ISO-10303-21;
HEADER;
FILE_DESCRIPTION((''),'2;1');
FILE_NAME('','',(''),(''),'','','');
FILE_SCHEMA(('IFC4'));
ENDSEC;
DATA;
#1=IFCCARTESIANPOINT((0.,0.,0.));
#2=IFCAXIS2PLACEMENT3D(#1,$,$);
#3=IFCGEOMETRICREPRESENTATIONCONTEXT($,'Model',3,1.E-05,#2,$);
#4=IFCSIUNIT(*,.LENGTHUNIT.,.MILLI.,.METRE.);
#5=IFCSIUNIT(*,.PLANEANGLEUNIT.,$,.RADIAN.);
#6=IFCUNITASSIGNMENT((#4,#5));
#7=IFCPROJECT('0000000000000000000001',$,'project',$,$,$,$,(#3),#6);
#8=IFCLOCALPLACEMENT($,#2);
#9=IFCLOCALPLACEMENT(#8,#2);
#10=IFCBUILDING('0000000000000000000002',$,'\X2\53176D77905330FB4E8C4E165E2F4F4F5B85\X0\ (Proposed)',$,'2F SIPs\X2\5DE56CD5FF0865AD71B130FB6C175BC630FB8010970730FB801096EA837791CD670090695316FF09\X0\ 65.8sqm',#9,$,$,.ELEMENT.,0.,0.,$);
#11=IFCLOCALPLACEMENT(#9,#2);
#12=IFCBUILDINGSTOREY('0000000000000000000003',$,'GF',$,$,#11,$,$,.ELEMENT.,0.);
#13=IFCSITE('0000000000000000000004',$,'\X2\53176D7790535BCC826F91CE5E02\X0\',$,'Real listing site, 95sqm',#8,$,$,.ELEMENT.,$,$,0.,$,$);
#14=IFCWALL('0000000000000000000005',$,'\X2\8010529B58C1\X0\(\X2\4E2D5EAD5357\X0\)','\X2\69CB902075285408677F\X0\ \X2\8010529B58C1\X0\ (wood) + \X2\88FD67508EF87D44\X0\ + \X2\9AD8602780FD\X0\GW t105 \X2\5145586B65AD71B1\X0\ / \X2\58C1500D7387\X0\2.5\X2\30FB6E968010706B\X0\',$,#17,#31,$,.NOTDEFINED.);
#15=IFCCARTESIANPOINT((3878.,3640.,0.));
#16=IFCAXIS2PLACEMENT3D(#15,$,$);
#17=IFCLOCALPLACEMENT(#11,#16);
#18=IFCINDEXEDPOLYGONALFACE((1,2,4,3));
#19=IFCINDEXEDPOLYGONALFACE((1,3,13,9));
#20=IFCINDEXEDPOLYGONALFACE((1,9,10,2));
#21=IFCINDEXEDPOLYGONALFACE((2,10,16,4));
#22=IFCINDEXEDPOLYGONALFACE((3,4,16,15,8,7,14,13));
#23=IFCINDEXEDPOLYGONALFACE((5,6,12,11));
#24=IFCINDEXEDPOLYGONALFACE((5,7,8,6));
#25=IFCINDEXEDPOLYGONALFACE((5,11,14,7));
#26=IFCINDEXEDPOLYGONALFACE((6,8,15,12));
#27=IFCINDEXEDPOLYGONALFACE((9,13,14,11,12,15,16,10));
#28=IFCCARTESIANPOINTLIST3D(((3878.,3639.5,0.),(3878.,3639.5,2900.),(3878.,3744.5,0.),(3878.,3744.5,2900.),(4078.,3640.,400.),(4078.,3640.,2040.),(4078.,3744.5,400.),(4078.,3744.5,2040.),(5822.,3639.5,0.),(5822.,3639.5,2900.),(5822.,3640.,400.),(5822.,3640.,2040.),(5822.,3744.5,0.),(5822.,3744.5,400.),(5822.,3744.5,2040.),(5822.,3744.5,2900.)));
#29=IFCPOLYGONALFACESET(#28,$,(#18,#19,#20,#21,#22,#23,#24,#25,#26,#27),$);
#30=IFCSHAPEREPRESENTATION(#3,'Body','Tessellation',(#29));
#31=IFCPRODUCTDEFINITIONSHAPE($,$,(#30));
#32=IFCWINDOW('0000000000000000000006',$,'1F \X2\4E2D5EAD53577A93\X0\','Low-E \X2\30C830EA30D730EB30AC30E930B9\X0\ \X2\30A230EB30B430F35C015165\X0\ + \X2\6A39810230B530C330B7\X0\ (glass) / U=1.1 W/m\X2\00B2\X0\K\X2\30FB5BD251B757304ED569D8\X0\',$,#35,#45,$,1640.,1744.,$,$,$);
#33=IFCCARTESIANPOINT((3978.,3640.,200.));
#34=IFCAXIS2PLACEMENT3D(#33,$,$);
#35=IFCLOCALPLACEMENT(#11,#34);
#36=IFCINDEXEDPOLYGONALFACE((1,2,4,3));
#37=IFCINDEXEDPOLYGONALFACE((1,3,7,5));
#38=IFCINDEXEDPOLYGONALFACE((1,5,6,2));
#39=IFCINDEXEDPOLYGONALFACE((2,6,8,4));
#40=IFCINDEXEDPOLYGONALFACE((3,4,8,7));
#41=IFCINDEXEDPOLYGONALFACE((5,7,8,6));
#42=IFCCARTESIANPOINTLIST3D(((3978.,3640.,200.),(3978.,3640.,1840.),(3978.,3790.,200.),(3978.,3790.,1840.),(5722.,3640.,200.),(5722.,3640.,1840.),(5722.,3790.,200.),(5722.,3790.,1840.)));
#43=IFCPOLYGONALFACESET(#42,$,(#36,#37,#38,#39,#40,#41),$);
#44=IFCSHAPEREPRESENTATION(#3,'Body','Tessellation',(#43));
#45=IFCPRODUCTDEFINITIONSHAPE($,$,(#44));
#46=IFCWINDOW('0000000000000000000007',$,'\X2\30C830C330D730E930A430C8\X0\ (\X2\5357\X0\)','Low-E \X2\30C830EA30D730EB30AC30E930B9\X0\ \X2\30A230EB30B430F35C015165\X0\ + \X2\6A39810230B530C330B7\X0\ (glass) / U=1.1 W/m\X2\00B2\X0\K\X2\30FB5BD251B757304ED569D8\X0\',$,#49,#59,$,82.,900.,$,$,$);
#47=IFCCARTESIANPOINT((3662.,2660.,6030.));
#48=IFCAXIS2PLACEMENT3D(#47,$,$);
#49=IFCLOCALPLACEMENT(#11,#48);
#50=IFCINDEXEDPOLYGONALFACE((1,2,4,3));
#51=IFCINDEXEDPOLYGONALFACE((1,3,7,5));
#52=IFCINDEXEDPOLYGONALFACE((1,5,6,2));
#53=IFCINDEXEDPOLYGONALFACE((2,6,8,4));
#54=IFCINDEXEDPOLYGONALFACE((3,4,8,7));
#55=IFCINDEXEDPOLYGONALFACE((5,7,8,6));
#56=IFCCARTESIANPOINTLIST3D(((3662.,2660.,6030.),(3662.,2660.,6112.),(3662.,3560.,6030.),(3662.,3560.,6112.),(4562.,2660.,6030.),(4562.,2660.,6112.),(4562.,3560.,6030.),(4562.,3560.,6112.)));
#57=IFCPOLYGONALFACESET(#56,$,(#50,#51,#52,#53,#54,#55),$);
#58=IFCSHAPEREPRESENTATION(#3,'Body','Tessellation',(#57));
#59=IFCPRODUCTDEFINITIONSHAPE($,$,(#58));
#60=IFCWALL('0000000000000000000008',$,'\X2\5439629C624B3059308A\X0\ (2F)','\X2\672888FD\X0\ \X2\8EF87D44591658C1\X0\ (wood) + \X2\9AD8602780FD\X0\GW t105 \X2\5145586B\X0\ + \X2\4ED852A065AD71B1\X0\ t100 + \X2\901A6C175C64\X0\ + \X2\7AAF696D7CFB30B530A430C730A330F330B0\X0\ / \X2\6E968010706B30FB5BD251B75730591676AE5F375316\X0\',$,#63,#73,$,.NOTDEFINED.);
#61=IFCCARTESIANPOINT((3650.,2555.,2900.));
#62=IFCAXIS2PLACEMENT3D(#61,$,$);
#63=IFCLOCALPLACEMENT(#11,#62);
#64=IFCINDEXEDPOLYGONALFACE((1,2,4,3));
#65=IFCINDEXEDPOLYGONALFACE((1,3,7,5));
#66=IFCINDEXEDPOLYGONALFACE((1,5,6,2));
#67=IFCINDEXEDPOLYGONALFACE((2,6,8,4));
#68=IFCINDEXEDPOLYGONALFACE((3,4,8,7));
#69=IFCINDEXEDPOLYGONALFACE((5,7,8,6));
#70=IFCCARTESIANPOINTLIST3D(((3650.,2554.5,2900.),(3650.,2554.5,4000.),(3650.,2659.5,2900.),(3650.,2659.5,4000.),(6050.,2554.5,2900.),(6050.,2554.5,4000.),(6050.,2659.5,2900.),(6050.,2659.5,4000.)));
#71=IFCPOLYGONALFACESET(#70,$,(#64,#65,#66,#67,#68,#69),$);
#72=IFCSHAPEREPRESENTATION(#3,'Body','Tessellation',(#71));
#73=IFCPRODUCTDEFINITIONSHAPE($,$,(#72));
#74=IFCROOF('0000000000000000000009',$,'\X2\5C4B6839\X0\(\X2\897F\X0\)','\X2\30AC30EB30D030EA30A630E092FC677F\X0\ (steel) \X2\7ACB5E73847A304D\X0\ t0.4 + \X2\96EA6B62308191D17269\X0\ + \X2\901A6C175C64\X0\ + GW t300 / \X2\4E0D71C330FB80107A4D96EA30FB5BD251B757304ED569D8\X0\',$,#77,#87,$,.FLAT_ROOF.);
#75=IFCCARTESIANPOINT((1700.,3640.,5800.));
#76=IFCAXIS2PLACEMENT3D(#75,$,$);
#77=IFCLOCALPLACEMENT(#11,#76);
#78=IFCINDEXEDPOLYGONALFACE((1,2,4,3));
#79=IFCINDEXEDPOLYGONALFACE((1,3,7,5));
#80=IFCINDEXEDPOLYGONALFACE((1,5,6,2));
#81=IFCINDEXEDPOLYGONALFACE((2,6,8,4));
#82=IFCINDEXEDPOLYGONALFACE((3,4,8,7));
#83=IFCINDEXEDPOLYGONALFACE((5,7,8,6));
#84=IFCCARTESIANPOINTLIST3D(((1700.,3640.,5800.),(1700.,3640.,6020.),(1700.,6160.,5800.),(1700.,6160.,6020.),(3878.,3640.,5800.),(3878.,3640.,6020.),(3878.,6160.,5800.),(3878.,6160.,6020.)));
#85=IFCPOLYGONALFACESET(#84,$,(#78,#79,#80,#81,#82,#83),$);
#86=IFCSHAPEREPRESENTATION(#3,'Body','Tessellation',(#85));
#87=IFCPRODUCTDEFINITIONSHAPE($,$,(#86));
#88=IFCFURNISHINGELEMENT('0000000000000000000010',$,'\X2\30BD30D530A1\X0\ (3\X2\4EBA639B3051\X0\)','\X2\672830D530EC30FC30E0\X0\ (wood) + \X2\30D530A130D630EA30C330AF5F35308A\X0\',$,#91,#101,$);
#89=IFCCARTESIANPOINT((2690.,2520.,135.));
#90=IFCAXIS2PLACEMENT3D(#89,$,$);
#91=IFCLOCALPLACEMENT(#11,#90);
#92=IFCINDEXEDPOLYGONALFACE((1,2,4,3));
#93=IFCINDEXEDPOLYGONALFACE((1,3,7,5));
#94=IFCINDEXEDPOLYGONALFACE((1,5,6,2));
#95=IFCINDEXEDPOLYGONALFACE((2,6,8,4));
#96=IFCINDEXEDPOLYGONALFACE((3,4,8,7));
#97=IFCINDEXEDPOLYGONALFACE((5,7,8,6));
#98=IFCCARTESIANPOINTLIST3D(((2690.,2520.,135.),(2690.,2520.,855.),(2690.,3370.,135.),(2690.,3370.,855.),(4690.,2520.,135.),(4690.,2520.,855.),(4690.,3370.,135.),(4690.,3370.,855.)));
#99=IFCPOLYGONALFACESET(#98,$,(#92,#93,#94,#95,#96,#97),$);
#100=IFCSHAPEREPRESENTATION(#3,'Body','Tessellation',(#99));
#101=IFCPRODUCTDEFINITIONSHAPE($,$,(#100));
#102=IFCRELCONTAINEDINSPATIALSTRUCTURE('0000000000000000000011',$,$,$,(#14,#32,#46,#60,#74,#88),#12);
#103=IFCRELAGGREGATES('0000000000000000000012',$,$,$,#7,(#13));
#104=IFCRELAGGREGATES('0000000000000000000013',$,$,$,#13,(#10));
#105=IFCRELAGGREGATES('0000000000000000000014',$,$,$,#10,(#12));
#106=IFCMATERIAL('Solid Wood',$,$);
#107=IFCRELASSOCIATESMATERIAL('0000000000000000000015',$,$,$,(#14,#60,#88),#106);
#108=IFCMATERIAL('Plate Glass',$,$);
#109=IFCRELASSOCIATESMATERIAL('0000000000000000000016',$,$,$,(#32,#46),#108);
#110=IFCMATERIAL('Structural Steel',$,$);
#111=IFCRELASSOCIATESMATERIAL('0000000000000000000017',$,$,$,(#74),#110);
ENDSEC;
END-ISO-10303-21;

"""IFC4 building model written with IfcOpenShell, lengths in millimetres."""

from ifc_helpers import new_model, si_unit, frame, frame_2d, origin, place, context, project, spatial, rectangle, extrude, material, element, fill, save


model = new_model("IFC4")

# Units and contexts
model_context = context("Model", 3, precision=1e-05, world=origin())
ifc_project = project(units=[si_unit("LENGTHUNIT", "METRE", prefix="MILLI"), si_unit("PLANEANGLEUNIT", "RADIAN")], contexts=[model_context])

# Site, building, storey
site_placement = place(None, origin())
site = spatial("IfcSite", under=ifc_project, at=site_placement, Name="北海道富良野市", ObjectType="Real listing site, 95sqm", CompositionType="ELEMENT", RefElevation=0.0)
building_placement = place(site_placement, origin())
building = spatial("IfcBuilding", under=site, at=building_placement, Name="北海道・二世帯住宅 (Proposed)", ObjectType="2F SIPs工法（断熱・気密・耐震・耐雪荷重最適化） 65.8sqm", CompositionType="ELEMENT", ElevationOfRefHeight=0.0, ElevationOfTerrain=0.0)
storey_placement = place(building_placement, origin())
storey = spatial("IfcBuildingStorey", under=building, at=storey_placement, Name="GF", CompositionType="ELEMENT", Elevation=0.0)

# Shared definitions
ifc_material_1 = material(Name="Solid Wood")

# Wall, opening, window
wall_1_placement = place(storey_placement, frame((3878.0, 3640.0, 0.0)))
wall_1 = element("IfcWall", 1, at=wall_1_placement, inside=storey, material=ifc_material_1, Name="耐力壁(中庭南)", Description="構造用合板 耐力壁 (wood) + 製材軸組 + 高性能GW t105 充填断熱 / 壁倍率2.5・準耐火", PredefinedType="NOTDEFINED", context=model_context, shape_type="SweptSolid", body=[
    extrude(rectangle(XDim=1944.0, YDim=105.0, at=frame_2d((972.0, 52.0))), frame((3878.0, 3640.0, 0.0)), (0.0, 0.0, 1.0), 2900.0),
])
opening_placement = place(storey_placement, frame((3978.0, 3640.0, 200.0)))
opening = element("IfcOpeningElement", 2, at=opening_placement, cuts=wall_1, PredefinedType="NOTDEFINED", context=model_context, shape_type="SweptSolid", body=[
    extrude(rectangle(XDim=1744.0, YDim=150.0, at=frame_2d((872.0, 75.0))), frame((3978.0, 3640.0, 200.0)), (0.0, 0.0, 1.0), 1640.0),
])
ifc_material_2 = material(Name="Plate Glass")
window_1_placement = place(storey_placement, frame((3978.0, 3640.0, 200.0)))
window_1 = element("IfcWindow", 3, at=window_1_placement, inside=storey, material=ifc_material_2, Name="1F 中庭南窓", Description="Low-E トリプルガラス アルゴン封入 + 樹脂サッシ (glass) / U=1.1 W/m²K・寒冷地仕様", OverallHeight=1640.0, OverallWidth=1744.0, context=model_context, shape_type="SweptSolid", body=[
    extrude(rectangle(XDim=1744.0, YDim=150.0, at=frame_2d((872.0, 75.0))), frame((3978.0, 3640.0, 200.0)), (0.0, 0.0, 1.0), 1640.0),
])
fill(opening, window_1)

# Window
window_2_placement = place(storey_placement, frame((3662.0, 2660.0, 6030.0)))
element("IfcWindow", 4, at=window_2_placement, inside=storey, material=ifc_material_2, Name="トップライト (南)", Description="Low-E トリプルガラス アルゴン封入 + 樹脂サッシ (glass) / U=1.1 W/m²K・寒冷地仕様", OverallHeight=82.0, OverallWidth=900.0, context=model_context, shape_type="SweptSolid", body=[
    extrude(rectangle(XDim=900.0, YDim=900.0, at=frame_2d((450.0, 450.0))), frame((3662.0, 2660.0, 6030.0)), (0.0, 0.0, 1.0), 82.0),
])

# Wall
wall_2_placement = place(storey_placement, frame((3650.0, 2555.0, 2900.0)))
element("IfcWall", 5, at=wall_2_placement, inside=storey, material=ifc_material_1, Name="吹抜手すり (2F)", Description="木製 軸組外壁 (wood) + 高性能GW t105 充填 + 付加断熱 t100 + 通気層 + 窯業系サイディング / 準耐火・寒冷地外皮強化", PredefinedType="NOTDEFINED", context=model_context, shape_type="SweptSolid", body=[
    extrude(rectangle(XDim=2400.0, YDim=105.0, at=frame_2d((1200.0, 52.0))), frame((3650.0, 2555.0, 2900.0)), (0.0, 0.0, 1.0), 1100.0),
])

# Roof
ifc_material_3 = material(Name="Structural Steel")
for number, where, name in (
    (6, (1700.0, 3640.0, 5800.0), "屋根(西)"),
):
    element("IfcRoof", number, at=place(storey_placement, frame(where)), inside=storey, material=ifc_material_3, Name=name, Description="ガルバリウム鋼板 (steel) 立平葺き t0.4 + 雪止め金物 + 通気層 + GW t300 / 不燃・耐積雪・寒冷地仕様", PredefinedType="FLAT_ROOF", context=model_context, shape_type="SweptSolid", body=[
        extrude(rectangle(XDim=2178.0, YDim=2520.0, at=frame_2d((1089.0, 1260.0))), frame((1700.0, 3640.0, 5800.0)), (0.0, 0.0, 1.0), 220.0),
    ])

# Furnishing element
furnishing_placement = place(storey_placement, frame((2690.0, 2520.0, 135.0)))
element("IfcFurnishingElement", 7, at=furnishing_placement, inside=storey, material=ifc_material_1, Name="ソファ (3人掛け)", Description="木フレーム (wood) + ファブリック張り", context=model_context, shape_type="SweptSolid", body=[
    extrude(rectangle(XDim=2000.0, YDim=850.0, at=frame_2d((1000.0, 425.0))), frame((2690.0, 2520.0, 135.0)), (0.0, 0.0, 1.0), 720.0),
])

save(model, "model.ifc")
